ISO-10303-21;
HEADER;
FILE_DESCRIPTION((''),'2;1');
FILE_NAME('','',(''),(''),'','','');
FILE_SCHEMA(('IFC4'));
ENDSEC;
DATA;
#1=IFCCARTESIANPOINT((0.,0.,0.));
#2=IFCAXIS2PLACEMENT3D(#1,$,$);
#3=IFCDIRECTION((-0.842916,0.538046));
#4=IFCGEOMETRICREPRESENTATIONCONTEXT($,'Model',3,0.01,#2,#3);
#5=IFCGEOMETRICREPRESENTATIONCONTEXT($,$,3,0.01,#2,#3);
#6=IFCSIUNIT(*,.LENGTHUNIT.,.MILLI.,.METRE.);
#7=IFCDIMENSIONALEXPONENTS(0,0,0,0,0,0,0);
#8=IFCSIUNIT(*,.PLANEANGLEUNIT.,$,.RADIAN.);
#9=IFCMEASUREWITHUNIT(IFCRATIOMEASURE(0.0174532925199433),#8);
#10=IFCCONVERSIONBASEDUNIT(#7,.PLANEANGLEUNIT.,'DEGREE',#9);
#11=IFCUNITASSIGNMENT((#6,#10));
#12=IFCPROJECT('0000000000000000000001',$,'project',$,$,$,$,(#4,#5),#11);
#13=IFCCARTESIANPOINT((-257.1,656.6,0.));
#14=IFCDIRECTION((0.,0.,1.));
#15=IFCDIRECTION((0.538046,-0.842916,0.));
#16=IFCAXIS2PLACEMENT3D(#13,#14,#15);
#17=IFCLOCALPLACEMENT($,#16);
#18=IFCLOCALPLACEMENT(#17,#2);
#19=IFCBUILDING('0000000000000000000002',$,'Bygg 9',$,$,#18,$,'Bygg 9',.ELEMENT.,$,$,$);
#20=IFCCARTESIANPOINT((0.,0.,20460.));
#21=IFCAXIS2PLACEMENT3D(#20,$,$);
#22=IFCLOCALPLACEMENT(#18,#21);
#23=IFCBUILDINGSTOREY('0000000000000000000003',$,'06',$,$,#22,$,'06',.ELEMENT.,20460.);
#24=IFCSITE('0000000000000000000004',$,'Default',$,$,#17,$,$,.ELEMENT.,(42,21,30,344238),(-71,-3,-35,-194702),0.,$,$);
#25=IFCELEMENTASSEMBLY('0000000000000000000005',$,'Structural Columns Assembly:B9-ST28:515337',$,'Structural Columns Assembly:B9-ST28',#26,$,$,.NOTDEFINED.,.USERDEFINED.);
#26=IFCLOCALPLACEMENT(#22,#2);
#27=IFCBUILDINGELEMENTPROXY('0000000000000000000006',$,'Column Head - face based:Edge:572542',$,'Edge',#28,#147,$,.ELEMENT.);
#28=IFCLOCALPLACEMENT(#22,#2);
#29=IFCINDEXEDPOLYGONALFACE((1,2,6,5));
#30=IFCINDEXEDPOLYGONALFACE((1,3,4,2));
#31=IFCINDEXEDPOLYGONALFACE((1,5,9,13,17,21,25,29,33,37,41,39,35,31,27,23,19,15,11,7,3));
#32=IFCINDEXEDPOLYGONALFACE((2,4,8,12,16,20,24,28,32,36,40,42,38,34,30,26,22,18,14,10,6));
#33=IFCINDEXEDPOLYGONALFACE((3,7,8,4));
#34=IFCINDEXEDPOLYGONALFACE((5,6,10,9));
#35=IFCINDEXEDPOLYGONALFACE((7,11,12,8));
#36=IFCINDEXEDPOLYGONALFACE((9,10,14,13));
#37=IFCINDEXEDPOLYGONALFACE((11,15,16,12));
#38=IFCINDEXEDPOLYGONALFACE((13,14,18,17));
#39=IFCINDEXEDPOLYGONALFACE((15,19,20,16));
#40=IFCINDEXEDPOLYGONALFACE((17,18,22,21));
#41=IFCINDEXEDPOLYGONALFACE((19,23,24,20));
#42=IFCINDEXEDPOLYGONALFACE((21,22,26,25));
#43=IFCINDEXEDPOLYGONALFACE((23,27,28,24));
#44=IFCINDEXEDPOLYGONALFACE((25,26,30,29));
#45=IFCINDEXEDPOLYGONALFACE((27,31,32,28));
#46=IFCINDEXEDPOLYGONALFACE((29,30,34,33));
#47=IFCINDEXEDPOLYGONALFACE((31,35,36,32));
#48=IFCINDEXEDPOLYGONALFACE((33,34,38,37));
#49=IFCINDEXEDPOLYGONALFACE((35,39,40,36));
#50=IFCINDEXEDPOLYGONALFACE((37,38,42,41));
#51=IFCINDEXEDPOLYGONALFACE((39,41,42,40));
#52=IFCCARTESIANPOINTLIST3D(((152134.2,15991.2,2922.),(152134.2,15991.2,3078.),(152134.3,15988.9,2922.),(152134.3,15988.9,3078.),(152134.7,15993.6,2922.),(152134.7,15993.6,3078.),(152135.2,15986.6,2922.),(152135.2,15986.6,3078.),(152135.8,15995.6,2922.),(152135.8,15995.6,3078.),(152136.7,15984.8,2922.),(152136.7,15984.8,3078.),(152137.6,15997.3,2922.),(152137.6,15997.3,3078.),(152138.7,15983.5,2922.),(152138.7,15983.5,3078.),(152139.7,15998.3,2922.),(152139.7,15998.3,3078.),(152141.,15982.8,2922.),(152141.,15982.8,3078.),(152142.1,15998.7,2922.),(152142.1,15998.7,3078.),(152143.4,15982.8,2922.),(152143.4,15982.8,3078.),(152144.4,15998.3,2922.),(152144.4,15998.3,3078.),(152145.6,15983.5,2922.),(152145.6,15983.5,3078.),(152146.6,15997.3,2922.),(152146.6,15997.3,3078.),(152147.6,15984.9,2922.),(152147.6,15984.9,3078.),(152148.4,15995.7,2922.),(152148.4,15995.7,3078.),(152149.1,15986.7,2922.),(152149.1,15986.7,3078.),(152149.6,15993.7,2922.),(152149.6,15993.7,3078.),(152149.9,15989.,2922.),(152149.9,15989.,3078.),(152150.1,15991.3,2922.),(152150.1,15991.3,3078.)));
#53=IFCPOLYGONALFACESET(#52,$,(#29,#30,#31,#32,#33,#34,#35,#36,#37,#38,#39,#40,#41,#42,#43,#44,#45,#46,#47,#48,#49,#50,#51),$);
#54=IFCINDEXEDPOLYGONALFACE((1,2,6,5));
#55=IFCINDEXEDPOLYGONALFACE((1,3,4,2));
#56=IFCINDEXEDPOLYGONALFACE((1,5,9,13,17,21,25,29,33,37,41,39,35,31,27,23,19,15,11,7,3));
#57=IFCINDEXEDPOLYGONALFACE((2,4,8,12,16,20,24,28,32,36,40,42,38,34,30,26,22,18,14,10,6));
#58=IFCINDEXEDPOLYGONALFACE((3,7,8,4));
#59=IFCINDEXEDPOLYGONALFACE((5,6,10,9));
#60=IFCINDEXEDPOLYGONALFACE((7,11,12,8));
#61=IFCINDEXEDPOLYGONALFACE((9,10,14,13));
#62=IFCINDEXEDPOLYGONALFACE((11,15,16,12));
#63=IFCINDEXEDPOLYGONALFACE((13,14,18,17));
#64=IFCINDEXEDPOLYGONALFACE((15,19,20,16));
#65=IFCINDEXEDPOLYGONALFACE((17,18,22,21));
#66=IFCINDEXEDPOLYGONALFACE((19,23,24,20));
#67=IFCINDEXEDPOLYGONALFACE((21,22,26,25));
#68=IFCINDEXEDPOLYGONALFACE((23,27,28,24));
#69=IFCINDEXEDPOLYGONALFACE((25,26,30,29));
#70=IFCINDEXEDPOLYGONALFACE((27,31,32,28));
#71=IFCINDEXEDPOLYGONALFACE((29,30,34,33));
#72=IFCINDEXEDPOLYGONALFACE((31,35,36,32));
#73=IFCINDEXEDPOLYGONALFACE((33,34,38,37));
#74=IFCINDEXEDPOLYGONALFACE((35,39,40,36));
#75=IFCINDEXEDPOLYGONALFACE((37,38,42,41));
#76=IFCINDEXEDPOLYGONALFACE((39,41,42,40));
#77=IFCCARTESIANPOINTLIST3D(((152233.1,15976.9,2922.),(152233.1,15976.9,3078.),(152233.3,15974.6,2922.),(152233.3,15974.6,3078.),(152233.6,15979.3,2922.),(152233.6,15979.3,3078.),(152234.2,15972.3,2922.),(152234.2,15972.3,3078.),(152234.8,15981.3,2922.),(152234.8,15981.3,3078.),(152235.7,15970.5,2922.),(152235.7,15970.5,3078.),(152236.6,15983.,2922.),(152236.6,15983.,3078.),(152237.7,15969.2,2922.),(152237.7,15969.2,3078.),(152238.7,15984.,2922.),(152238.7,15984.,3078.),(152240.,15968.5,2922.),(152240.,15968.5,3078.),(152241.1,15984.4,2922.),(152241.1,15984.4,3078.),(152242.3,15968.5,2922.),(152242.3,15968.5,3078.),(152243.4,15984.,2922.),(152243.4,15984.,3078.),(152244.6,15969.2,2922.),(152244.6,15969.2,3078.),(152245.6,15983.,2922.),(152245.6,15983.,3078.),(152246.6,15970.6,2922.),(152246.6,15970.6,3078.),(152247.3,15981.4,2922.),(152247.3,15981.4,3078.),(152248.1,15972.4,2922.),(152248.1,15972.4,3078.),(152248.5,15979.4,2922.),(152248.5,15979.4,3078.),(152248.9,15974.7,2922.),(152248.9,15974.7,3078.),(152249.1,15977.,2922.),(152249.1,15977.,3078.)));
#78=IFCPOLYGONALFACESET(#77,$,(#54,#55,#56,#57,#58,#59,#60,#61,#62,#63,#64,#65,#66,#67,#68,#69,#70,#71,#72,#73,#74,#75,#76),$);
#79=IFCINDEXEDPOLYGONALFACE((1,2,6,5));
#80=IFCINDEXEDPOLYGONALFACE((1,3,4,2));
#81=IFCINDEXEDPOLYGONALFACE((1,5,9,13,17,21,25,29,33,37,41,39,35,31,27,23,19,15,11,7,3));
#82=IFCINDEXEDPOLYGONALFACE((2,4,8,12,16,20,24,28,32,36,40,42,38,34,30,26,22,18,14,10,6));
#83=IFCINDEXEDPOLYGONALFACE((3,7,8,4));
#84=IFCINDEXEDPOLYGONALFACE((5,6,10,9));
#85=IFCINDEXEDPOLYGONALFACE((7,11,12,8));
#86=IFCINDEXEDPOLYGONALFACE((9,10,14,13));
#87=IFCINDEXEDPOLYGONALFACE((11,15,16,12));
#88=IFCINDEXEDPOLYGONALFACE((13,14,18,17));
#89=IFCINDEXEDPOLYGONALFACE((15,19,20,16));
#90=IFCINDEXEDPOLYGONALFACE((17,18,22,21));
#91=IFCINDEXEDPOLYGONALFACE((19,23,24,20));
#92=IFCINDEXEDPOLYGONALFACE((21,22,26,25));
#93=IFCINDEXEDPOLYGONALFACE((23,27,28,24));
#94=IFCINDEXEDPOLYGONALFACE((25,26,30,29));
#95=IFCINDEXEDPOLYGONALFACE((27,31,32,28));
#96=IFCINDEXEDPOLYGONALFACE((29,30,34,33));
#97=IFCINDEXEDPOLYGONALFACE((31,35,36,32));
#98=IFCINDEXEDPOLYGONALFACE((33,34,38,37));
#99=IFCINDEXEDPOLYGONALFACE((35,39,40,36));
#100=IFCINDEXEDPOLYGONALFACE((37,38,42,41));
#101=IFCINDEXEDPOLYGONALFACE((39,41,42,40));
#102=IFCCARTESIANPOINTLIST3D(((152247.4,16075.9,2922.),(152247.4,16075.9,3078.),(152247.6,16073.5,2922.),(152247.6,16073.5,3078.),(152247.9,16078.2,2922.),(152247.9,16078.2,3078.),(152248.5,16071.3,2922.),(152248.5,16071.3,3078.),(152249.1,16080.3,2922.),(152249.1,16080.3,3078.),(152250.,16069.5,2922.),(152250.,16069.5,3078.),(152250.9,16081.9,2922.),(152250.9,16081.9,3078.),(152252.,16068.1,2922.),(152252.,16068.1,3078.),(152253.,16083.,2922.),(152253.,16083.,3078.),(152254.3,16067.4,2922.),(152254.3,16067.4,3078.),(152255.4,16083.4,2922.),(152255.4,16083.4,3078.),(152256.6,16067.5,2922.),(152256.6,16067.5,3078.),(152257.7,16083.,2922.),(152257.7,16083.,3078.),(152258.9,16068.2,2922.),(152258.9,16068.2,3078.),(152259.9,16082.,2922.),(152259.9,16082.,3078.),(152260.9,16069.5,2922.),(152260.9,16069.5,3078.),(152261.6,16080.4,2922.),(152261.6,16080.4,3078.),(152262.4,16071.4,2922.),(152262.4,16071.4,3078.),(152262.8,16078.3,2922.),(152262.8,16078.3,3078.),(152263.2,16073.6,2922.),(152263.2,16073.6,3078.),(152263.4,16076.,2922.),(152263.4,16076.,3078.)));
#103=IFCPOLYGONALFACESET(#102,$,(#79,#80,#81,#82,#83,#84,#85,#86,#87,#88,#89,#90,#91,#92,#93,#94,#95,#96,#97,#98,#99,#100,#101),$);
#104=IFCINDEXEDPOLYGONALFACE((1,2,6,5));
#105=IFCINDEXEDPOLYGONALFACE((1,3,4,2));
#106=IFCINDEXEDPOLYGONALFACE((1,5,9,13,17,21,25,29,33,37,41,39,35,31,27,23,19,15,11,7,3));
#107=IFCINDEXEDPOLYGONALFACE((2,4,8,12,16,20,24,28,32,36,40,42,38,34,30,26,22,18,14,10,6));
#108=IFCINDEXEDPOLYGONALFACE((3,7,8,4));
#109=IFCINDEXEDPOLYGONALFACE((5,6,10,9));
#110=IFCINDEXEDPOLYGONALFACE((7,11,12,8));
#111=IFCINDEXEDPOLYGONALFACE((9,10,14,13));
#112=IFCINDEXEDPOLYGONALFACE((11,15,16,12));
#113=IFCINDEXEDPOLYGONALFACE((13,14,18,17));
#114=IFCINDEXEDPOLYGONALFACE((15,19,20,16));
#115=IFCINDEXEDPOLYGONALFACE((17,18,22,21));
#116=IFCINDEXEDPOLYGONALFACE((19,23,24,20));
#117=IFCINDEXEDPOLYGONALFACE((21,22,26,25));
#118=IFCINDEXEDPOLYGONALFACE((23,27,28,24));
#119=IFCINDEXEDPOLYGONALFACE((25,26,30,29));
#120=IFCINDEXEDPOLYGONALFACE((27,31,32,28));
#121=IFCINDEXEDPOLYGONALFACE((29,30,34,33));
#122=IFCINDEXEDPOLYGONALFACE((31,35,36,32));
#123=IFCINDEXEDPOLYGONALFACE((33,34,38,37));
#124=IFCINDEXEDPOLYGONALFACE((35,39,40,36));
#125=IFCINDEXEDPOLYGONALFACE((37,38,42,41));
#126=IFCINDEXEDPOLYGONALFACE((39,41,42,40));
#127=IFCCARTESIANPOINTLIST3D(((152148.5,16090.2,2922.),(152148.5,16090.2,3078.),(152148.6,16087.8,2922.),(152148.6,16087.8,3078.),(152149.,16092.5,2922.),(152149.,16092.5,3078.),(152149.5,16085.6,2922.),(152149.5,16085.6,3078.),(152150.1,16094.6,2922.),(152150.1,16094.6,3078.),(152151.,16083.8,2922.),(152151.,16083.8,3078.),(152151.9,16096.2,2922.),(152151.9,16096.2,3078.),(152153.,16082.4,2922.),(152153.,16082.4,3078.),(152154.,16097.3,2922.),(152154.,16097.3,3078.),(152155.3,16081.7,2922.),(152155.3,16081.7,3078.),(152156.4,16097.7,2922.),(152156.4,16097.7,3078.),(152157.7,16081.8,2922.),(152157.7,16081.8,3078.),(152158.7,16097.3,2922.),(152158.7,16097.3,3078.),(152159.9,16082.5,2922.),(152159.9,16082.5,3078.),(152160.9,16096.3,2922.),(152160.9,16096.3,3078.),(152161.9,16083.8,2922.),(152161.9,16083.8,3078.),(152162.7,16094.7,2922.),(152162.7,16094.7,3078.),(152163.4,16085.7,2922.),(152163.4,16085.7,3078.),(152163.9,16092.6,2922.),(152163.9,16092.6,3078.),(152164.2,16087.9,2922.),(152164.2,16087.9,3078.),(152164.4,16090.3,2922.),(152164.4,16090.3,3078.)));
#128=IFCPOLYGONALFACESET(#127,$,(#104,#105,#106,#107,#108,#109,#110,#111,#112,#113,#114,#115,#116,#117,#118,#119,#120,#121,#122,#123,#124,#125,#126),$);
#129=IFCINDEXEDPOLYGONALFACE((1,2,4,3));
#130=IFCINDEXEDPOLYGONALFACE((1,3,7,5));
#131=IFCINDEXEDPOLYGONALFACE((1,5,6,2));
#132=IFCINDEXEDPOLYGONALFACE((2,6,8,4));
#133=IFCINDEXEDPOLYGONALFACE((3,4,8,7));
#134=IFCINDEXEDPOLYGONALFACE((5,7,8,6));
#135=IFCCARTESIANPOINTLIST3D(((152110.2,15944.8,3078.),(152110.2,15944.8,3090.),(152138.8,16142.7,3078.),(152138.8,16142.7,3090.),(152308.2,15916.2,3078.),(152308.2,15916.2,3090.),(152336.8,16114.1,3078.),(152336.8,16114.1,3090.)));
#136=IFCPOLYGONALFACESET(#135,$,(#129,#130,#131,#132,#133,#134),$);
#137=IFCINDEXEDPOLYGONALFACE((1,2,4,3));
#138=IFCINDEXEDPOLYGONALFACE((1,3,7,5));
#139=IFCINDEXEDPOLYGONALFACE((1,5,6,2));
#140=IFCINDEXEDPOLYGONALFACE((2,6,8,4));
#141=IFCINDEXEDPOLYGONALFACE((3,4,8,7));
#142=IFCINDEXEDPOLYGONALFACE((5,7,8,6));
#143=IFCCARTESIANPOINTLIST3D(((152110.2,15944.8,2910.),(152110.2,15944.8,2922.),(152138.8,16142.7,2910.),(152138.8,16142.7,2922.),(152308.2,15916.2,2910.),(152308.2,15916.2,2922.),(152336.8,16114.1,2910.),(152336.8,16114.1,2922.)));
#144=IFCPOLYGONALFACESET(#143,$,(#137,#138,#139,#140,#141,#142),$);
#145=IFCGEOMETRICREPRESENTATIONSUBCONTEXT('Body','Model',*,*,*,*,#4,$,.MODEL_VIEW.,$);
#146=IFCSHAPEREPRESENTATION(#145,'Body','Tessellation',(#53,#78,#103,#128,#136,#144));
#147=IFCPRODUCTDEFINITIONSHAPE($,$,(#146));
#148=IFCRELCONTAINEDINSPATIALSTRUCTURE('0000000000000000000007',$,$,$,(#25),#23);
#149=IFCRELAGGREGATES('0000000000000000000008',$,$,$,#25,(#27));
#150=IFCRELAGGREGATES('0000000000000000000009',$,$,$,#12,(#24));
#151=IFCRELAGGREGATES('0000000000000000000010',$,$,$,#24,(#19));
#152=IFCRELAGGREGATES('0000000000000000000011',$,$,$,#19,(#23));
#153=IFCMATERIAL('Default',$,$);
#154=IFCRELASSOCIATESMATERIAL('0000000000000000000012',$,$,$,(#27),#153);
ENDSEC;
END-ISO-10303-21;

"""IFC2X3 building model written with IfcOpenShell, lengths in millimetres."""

from ifc_helpers import new_model, entity, si_unit, converted_unit, direction, frame, frame_2d, origin, origin_2d_with_axis, place, context, subcontext, project, spatial, rectangle, circle, extrude, source, transform, mapped, material, element, aggregate, save


model = new_model("IFC2X3")

# Units and contexts
model_context = context("Model", 3, precision=0.01, world=origin(), true_north=direction((-0.842916, 0.538046)))
context_of_model = context(None, 3, precision=0.01, world=origin(), true_north=direction((-0.842916, 0.538046)))
body_context = subcontext(model_context, "Body", "Model", "MODEL_VIEW")
ifc_project = project(units=[si_unit("LENGTHUNIT", "METRE", prefix="MILLI"), converted_unit("PLANEANGLEUNIT", "DEGREE", entity("IfcRatioMeasure", 0.0174532925199433), si_unit("PLANEANGLEUNIT", "RADIAN"), dimensions=[0, 0, 0, 0, 0, 0, 0])], contexts=[model_context, context_of_model])

# Site, building, storey
site_placement = place(None, frame((-257.1, 656.6, 0.0), z_axis=(0.0, 0.0, 1.0), x_axis=(0.538046, -0.842916, 0.0)))
site = spatial("IfcSite", under=ifc_project, at=site_placement, Name="Default", CompositionType="ELEMENT", RefLatitude=(42, 21, 30, 344238), RefLongitude=(-71, -3, -35, -194702), RefElevation=0.0)
building_placement = place(site_placement, origin())
building = spatial("IfcBuilding", under=site, at=building_placement, Name="Bygg 9", LongName="Bygg 9", CompositionType="ELEMENT")
storey_placement = place(building_placement, frame((0.0, 0.0, 20460.0)))
storey = spatial("IfcBuildingStorey", under=building, at=storey_placement, Name="06", LongName="06", CompositionType="ELEMENT", Elevation=20460.0)

# Element assembly
assembly_1_placement = place(storey_placement, origin())
assembly_1 = element("IfcElementAssembly", 1, at=assembly_1_placement, inside=storey, Name="Structural Columns Assembly:B9-ST28:515337", ObjectType="Structural Columns Assembly:B9-ST28", AssemblyPlace="NOTDEFINED", PredefinedType="USERDEFINED")

# Shared definitions
ifc_material_1 = material(Name="Default")

# Building element proxy
shared_shape_1 = source(origin(), body_context, "Body", "SweptSolid", [
    extrude(circle(Radius=8.0, at=frame_2d((0.0, 0.0), x_axis=(1.0, 0.0))), frame((50.0, -75.0, 12.0)), (0.0, 0.0, 1.0), 156.0),
    extrude(circle(Radius=8.0, at=frame_2d((0.0, 0.0), x_axis=(1.0, 0.0))), frame((50.0, 25.0, 12.0)), (0.0, 0.0, 1.0), 156.0),
    extrude(circle(Radius=8.0, at=frame_2d((0.0, 0.0), x_axis=(1.0, 0.0))), frame((-50.0, 25.0, 12.0)), (0.0, 0.0, 1.0), 156.0),
    extrude(circle(Radius=8.0, at=frame_2d((0.0, 0.0), x_axis=(1.0, 0.0))), frame((-50.0, -75.0, 12.0)), (0.0, 0.0, 1.0), 156.0),
    extrude(rectangle(XDim=200.0, YDim=200.0, at=origin_2d_with_axis()), frame((0.0, 0.0, 168.0), z_axis=(0.0, 0.0, 1.0), x_axis=(-1.0, 0.0, 0.0)), (0.0, 0.0, 1.0), 12.0),
    extrude(rectangle(XDim=200.0, YDim=200.0, at=origin_2d_with_axis()), frame((0.0, 0.0, 0.0), z_axis=(0.0, 0.0, 1.0), x_axis=(0.0, 1.0, 0.0)), (0.0, 0.0, 1.0), 12.0),
])
proxy_1_placement = place(assembly_1_placement, frame((152223.5, 16029.4, 2910.0), z_axis=(0.0, 0.0, 1.0), x_axis=(-0.142999, -0.989723, 0.0)))
proxy_1 = element("IfcBuildingElementProxy", 2, at=proxy_1_placement, material=ifc_material_1, Name="Column Head - face based:Edge:572542", ObjectType="Edge", CompositionType="ELEMENT", context=body_context, shape_type="MappedRepresentation", body=[
    mapped(shared_shape_1, transform((0.0, 0.0, 0.0), scale=1.0)),
])
aggregate(assembly_1, [proxy_1])

save(model, "model.ifc")
